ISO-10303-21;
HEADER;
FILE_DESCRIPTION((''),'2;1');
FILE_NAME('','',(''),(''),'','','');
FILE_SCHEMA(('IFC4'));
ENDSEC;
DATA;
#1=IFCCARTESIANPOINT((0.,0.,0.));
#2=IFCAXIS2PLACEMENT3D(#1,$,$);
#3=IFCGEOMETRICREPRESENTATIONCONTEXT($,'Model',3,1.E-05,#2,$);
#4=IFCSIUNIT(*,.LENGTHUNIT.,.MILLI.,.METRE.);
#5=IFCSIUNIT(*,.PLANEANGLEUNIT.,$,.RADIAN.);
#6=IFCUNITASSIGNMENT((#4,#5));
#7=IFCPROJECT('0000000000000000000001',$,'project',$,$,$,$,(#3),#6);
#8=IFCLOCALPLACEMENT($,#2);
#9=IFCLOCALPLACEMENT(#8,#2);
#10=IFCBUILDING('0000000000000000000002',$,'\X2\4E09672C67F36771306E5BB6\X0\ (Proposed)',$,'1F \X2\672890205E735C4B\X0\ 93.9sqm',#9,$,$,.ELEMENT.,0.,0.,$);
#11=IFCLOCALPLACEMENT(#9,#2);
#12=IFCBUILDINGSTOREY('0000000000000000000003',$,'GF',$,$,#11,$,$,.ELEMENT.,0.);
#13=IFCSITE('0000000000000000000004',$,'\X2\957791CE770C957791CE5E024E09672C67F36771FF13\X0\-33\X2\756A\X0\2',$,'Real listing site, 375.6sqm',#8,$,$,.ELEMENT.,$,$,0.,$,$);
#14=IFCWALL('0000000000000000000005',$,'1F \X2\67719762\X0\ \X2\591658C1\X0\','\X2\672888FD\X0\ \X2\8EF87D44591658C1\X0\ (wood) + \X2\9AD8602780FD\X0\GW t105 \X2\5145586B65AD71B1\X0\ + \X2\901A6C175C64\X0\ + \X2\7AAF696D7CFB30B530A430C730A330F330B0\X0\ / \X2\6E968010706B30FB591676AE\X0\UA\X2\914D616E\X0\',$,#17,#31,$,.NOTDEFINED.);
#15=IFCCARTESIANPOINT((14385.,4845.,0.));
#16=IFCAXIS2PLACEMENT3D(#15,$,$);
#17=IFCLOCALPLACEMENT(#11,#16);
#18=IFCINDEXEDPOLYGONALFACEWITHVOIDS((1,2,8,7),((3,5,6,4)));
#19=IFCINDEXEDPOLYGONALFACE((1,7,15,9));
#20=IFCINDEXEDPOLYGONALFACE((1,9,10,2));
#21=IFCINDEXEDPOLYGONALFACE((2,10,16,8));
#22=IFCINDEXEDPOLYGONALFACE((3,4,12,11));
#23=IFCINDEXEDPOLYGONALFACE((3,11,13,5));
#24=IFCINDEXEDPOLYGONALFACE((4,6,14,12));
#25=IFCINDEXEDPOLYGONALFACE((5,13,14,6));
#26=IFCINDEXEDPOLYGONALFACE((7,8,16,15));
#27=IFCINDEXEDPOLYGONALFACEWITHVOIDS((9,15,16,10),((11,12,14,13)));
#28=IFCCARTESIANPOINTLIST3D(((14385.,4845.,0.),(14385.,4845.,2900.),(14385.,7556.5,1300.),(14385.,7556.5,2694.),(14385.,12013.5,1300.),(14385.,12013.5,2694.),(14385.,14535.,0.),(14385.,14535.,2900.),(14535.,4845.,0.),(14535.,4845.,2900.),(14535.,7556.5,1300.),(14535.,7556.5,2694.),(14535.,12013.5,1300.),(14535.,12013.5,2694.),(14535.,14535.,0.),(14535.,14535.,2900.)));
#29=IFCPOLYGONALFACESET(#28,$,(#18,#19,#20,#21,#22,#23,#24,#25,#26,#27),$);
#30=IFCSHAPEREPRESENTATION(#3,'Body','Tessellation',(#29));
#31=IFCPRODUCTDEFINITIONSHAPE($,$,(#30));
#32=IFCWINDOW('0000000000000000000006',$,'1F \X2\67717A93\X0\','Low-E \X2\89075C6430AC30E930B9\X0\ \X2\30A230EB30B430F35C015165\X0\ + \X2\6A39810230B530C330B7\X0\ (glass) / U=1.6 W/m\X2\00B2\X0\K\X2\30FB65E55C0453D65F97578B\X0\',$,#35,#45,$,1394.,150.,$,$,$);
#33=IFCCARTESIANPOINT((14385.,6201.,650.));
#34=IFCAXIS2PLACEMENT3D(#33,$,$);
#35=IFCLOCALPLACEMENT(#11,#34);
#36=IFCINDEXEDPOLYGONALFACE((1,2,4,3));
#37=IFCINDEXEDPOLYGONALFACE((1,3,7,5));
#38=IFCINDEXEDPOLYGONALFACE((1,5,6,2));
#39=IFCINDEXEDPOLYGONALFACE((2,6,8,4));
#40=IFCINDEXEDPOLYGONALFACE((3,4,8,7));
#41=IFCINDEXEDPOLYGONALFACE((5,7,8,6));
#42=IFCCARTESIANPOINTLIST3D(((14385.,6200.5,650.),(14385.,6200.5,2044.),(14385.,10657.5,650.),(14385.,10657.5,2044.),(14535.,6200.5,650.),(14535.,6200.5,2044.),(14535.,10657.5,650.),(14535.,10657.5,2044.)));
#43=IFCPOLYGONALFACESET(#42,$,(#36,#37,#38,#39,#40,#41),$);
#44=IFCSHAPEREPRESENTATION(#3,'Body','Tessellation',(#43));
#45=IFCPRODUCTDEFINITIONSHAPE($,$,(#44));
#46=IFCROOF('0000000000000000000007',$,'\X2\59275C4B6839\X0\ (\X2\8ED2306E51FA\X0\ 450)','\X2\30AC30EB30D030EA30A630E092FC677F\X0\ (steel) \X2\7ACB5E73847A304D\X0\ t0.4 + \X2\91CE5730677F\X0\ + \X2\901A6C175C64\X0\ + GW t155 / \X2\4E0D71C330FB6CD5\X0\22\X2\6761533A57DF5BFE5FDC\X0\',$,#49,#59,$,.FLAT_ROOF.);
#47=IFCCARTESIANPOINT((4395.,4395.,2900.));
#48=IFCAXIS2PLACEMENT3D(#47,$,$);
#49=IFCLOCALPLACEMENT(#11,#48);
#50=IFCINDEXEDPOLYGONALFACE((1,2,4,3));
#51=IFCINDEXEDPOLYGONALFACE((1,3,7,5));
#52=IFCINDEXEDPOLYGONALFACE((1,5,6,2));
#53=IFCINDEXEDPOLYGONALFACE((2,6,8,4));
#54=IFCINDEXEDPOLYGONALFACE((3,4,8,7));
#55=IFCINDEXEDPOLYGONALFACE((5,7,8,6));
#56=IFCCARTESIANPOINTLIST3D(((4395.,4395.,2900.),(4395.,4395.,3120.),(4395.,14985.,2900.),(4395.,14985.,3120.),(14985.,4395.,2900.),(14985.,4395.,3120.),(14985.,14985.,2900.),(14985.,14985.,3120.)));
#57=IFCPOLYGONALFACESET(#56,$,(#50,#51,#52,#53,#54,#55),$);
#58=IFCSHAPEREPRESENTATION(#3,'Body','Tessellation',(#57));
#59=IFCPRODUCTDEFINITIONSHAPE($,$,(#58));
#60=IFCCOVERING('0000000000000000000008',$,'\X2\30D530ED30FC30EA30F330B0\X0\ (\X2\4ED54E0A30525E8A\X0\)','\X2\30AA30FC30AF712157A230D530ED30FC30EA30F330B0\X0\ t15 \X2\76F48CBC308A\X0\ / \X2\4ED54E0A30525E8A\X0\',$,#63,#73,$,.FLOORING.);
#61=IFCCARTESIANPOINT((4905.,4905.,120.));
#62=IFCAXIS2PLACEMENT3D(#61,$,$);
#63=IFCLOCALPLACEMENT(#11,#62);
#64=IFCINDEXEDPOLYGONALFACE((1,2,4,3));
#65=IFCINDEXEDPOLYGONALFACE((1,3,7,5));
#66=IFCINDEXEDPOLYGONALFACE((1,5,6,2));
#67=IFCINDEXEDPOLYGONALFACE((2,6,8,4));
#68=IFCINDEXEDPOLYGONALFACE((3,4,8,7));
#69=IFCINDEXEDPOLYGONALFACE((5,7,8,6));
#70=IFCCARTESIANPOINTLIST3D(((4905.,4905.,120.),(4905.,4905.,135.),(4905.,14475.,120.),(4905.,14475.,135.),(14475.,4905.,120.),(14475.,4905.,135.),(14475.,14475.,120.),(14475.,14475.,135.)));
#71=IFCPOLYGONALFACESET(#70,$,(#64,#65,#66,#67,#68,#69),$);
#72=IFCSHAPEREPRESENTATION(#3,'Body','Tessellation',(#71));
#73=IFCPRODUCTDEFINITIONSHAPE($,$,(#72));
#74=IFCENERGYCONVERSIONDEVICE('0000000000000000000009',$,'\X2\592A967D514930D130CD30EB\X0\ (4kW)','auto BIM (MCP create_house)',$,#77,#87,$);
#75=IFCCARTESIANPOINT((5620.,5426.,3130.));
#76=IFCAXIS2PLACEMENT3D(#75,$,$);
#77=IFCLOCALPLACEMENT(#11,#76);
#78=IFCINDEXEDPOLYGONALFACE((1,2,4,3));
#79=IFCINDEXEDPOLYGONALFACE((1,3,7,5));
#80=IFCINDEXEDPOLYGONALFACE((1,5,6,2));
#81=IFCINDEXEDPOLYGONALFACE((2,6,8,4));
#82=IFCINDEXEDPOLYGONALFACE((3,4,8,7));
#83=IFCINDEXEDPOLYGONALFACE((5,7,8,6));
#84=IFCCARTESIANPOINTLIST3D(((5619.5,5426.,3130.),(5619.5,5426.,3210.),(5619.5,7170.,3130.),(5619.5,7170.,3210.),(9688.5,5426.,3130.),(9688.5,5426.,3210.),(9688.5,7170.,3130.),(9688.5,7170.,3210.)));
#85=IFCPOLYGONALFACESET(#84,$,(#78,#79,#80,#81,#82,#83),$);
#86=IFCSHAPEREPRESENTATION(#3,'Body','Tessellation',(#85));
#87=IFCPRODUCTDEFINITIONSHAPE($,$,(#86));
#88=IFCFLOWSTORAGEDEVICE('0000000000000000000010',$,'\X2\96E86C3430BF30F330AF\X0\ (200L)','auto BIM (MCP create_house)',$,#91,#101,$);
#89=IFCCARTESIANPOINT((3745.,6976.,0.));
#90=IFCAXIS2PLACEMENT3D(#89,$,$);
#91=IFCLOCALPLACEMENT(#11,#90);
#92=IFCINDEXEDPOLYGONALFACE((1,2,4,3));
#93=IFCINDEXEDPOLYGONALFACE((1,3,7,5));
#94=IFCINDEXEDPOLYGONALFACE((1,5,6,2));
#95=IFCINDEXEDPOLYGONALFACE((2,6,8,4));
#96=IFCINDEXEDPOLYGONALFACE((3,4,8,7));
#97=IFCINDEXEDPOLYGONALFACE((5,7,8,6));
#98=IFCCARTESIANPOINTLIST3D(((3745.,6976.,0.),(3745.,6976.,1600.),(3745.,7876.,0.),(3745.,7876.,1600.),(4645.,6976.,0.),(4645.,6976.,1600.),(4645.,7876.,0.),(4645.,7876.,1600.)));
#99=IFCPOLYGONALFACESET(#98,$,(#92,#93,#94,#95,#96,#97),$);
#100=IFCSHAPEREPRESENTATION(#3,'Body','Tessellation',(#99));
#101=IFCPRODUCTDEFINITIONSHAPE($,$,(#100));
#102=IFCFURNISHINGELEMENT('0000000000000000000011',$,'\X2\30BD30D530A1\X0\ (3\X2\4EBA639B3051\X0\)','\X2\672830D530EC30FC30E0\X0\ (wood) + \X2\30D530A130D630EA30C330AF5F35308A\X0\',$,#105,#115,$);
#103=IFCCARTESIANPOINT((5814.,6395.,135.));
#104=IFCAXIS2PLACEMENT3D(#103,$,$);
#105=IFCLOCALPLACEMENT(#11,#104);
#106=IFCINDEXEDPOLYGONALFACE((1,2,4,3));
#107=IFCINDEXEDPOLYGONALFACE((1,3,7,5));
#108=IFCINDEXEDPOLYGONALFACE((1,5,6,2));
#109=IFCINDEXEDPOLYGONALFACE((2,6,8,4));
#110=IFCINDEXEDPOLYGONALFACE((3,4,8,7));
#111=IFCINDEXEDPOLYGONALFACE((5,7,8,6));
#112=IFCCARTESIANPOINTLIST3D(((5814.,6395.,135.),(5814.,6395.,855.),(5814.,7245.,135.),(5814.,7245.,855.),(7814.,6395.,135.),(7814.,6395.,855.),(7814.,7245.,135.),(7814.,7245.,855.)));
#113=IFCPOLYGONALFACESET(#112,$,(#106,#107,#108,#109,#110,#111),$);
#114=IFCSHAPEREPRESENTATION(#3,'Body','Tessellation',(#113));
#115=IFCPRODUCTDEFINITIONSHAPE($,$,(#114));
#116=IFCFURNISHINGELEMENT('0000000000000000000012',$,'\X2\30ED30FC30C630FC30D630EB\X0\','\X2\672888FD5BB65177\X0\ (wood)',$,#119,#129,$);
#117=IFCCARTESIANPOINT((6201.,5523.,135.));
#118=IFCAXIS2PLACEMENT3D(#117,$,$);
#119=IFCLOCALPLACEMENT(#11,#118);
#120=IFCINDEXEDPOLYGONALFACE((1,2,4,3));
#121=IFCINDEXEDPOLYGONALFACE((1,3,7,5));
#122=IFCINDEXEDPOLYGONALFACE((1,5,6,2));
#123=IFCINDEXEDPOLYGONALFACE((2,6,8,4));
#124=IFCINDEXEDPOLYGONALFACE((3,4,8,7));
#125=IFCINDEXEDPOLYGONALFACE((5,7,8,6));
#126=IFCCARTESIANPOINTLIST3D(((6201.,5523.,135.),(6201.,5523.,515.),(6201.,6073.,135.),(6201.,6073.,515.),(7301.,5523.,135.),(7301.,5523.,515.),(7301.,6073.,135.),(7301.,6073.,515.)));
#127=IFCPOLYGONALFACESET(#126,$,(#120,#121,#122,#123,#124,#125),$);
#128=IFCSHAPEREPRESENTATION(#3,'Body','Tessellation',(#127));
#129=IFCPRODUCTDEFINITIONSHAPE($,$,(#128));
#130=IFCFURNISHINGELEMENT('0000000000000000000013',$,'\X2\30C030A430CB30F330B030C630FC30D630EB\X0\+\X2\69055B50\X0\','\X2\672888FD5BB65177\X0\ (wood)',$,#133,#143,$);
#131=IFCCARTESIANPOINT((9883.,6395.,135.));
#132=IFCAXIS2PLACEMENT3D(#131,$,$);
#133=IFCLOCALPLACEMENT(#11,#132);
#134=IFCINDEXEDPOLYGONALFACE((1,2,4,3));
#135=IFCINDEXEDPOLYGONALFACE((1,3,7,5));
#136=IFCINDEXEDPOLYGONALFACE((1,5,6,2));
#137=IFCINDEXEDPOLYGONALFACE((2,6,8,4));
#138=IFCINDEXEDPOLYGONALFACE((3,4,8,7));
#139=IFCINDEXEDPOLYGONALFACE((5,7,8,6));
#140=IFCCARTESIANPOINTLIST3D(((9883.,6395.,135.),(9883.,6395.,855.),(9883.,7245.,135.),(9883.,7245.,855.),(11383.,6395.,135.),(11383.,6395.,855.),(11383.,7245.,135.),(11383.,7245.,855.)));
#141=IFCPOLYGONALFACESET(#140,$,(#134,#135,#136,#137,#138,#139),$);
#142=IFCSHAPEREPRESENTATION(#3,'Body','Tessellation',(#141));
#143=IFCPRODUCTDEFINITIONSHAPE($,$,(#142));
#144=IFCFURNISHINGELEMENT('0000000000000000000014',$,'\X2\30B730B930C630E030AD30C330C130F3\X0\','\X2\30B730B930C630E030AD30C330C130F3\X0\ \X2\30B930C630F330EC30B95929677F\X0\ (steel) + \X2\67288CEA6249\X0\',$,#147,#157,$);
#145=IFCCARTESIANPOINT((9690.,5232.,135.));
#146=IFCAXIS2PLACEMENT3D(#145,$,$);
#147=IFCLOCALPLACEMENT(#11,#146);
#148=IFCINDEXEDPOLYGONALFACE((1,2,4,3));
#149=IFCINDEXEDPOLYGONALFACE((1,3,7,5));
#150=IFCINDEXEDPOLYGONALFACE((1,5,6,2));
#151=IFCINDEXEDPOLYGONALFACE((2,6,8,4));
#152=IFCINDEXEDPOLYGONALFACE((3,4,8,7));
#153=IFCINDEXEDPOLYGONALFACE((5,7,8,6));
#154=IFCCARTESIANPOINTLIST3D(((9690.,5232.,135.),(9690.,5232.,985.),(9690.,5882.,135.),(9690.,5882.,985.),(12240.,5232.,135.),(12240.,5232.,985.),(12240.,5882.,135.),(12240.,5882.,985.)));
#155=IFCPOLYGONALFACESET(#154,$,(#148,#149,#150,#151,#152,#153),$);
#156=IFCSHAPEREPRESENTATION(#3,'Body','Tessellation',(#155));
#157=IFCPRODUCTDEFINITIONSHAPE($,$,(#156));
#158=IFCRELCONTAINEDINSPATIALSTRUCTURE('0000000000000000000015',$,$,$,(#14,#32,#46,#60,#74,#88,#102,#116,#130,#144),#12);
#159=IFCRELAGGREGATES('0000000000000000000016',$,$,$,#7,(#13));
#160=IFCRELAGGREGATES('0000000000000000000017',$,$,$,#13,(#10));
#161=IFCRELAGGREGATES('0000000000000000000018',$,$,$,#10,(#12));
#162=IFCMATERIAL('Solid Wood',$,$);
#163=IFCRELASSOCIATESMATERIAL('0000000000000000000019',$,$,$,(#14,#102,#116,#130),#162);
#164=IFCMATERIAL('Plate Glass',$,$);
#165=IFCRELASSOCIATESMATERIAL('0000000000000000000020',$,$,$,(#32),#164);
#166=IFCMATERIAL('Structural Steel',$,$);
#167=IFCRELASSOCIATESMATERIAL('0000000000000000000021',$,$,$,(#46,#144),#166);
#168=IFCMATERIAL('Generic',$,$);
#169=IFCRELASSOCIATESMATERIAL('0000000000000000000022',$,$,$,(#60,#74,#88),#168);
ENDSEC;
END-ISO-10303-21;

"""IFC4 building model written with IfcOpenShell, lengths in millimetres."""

from ifc_helpers import new_model, si_unit, frame, frame_2d, origin, place, context, project, spatial, rectangle, extrude, material, element, fill, save


model = new_model("IFC4")

# Units and contexts
model_context = context("Model", 3, precision=1e-05, world=origin())
ifc_project = project(units=[si_unit("LENGTHUNIT", "METRE", prefix="MILLI"), si_unit("PLANEANGLEUNIT", "RADIAN")], contexts=[model_context])

# Site, building, storey
site_placement = place(None, origin())
site = spatial("IfcSite", under=ifc_project, at=site_placement, Name="長野県長野市三本柳東３-33番2", ObjectType="Real listing site, 375.6sqm", CompositionType="ELEMENT", RefElevation=0.0)
building_placement = place(site_placement, origin())
building = spatial("IfcBuilding", under=site, at=building_placement, Name="三本柳東の家 (Proposed)", ObjectType="1F 木造平屋 93.9sqm", CompositionType="ELEMENT", ElevationOfRefHeight=0.0, ElevationOfTerrain=0.0)
storey_placement = place(building_placement, origin())
storey = spatial("IfcBuildingStorey", under=building, at=storey_placement, Name="GF", CompositionType="ELEMENT", Elevation=0.0)

# Shared definitions
ifc_material_1 = material(Name="Solid Wood")

# Shared definitions
ifc_material_2 = material(Name="Plate Glass")

# Wall, opening, window
wall_1_placement = place(storey_placement, frame((14385.0, 4845.0, 0.0)))
wall_1 = element("IfcWall", 1, at=wall_1_placement, inside=storey, material=ifc_material_1, Name="1F 東面 外壁", Description="木製 軸組外壁 (wood) + 高性能GW t105 充填断熱 + 通気層 + 窯業系サイディング / 準耐火・外皮UA配慮", PredefinedType="NOTDEFINED", context=model_context, shape_type="SweptSolid", body=[
    extrude(rectangle(XDim=150.0, YDim=9690.0, at=frame_2d((75.0, 4845.0))), frame((14385.0, 4845.0, 0.0)), (0.0, 0.0, 1.0), 2900.0),
])
opening_1_placement = place(storey_placement, frame((14385.0, 6201.0, 650.0)))
opening_1 = element("IfcOpeningElement", 2, at=opening_1_placement, cuts=wall_1, PredefinedType="NOTDEFINED", context=model_context, shape_type="SweptSolid", body=[
    extrude(rectangle(XDim=150.0, YDim=4457.0, at=frame_2d((75.0, 2228.0))), frame((14385.0, 6201.0, 650.0)), (0.0, 0.0, 1.0), 1394.0),
])
window_1_placement = place(storey_placement, frame((14385.0, 6201.0, 650.0)))
window_1 = element("IfcWindow", 3, at=window_1_placement, inside=storey, material=ifc_material_2, Name="1F 東窓", Description="Low-E 複層ガラス アルゴン封入 + 樹脂サッシ (glass) / U=1.6 W/m²K・日射取得型", OverallHeight=1394.0, OverallWidth=150.0, context=model_context, shape_type="SweptSolid", body=[
    extrude(rectangle(XDim=150.0, YDim=4457.0, at=frame_2d((75.0, 2228.0))), frame((14385.0, 6201.0, 650.0)), (0.0, 0.0, 1.0), 1394.0),
])
fill(opening_1, window_1)

# Roof
ifc_material_3 = material(Name="Structural Steel")
roof_placement = place(storey_placement, frame((4395.0, 4395.0, 2900.0)))
element("IfcRoof", 4, at=roof_placement, inside=storey, material=ifc_material_3, Name="大屋根 (軒の出 450)", Description="ガルバリウム鋼板 (steel) 立平葺き t0.4 + 野地板 + 通気層 + GW t155 / 不燃・法22条区域対応", PredefinedType="FLAT_ROOF", context=model_context, shape_type="SweptSolid", body=[
    extrude(rectangle(XDim=10590.0, YDim=10590.0, at=frame_2d((5295.0, 5295.0))), frame((4395.0, 4395.0, 2900.0)), (0.0, 0.0, 1.0), 220.0),
])

# Covering
ifc_material_4 = material(Name="Generic")
covering_placement = place(storey_placement, frame((4905.0, 4905.0, 120.0)))
element("IfcCovering", 5, at=covering_placement, inside=storey, material=ifc_material_4, Name="フローリング (仕上げ床)", Description="オーク無垢フローリング t15 直貼り / 仕上げ床", PredefinedType="FLOORING", context=model_context, shape_type="SweptSolid", body=[
    extrude(rectangle(XDim=9570.0, YDim=9570.0, at=frame_2d((4785.0, 4785.0))), frame((4905.0, 4905.0, 120.0)), (0.0, 0.0, 1.0), 15.0),
])

# Energy conversion device
energy_conversion_device_placement = place(storey_placement, frame((5620.0, 5426.0, 3130.0)))
element("IfcEnergyConversionDevice", 6, at=energy_conversion_device_placement, inside=storey, material=ifc_material_4, Name="太陽光パネル (4kW)", Description="auto BIM (MCP create_house)", context=model_context, shape_type="SweptSolid", body=[
    extrude(rectangle(XDim=4069.0, YDim=1744.0, at=frame_2d((2034.0, 872.0))), frame((5620.0, 5426.0, 3130.0)), (0.0, 0.0, 1.0), 80.0),
])

# Flow storage device
flow_storage_device_placement = place(storey_placement, frame((3745.0, 6976.0, 0.0)))
element("IfcFlowStorageDevice", 7, at=flow_storage_device_placement, inside=storey, material=ifc_material_4, Name="雨水タンク (200L)", Description="auto BIM (MCP create_house)", context=model_context, shape_type="SweptSolid", body=[
    extrude(rectangle(XDim=900.0, YDim=900.0, at=frame_2d((450.0, 450.0))), frame((3745.0, 6976.0, 0.0)), (0.0, 0.0, 1.0), 1600.0),
])

# Furnishing elements
furnishing_1_placement = place(storey_placement, frame((5814.0, 6395.0, 135.0)))
element("IfcFurnishingElement", 8, at=furnishing_1_placement, inside=storey, material=ifc_material_1, Name="ソファ (3人掛け)", Description="木フレーム (wood) + ファブリック張り", context=model_context, shape_type="SweptSolid", body=[
    extrude(rectangle(XDim=2000.0, YDim=850.0, at=frame_2d((1000.0, 425.0))), frame((5814.0, 6395.0, 135.0)), (0.0, 0.0, 1.0), 720.0),
])
furnishing_2_placement = place(storey_placement, frame((6201.0, 5523.0, 135.0)))
element("IfcFurnishingElement", 9, at=furnishing_2_placement, inside=storey, material=ifc_material_1, Name="ローテーブル", Description="木製家具 (wood)", context=model_context, shape_type="SweptSolid", body=[
    extrude(rectangle(XDim=1100.0, YDim=550.0, at=frame_2d((550.0, 275.0))), frame((6201.0, 5523.0, 135.0)), (0.0, 0.0, 1.0), 380.0),
])
furnishing_3_placement = place(storey_placement, frame((9883.0, 6395.0, 135.0)))
element("IfcFurnishingElement", 10, at=furnishing_3_placement, inside=storey, material=ifc_material_1, Name="ダイニングテーブル+椅子", Description="木製家具 (wood)", context=model_context, shape_type="SweptSolid", body=[
    extrude(rectangle(XDim=1500.0, YDim=850.0, at=frame_2d((750.0, 425.0))), frame((9883.0, 6395.0, 135.0)), (0.0, 0.0, 1.0), 720.0),
])
furnishing_4_placement = place(storey_placement, frame((9690.0, 5232.0, 135.0)))
element("IfcFurnishingElement", 11, at=furnishing_4_placement, inside=storey, material=ifc_material_3, Name="システムキッチン", Description="システムキッチン ステンレス天板 (steel) + 木質扉", context=model_context, shape_type="SweptSolid", body=[
    extrude(rectangle(XDim=2550.0, YDim=650.0, at=frame_2d((1275.0, 325.0))), frame((9690.0, 5232.0, 135.0)), (0.0, 0.0, 1.0), 850.0),
])

save(model, "model.ifc")
